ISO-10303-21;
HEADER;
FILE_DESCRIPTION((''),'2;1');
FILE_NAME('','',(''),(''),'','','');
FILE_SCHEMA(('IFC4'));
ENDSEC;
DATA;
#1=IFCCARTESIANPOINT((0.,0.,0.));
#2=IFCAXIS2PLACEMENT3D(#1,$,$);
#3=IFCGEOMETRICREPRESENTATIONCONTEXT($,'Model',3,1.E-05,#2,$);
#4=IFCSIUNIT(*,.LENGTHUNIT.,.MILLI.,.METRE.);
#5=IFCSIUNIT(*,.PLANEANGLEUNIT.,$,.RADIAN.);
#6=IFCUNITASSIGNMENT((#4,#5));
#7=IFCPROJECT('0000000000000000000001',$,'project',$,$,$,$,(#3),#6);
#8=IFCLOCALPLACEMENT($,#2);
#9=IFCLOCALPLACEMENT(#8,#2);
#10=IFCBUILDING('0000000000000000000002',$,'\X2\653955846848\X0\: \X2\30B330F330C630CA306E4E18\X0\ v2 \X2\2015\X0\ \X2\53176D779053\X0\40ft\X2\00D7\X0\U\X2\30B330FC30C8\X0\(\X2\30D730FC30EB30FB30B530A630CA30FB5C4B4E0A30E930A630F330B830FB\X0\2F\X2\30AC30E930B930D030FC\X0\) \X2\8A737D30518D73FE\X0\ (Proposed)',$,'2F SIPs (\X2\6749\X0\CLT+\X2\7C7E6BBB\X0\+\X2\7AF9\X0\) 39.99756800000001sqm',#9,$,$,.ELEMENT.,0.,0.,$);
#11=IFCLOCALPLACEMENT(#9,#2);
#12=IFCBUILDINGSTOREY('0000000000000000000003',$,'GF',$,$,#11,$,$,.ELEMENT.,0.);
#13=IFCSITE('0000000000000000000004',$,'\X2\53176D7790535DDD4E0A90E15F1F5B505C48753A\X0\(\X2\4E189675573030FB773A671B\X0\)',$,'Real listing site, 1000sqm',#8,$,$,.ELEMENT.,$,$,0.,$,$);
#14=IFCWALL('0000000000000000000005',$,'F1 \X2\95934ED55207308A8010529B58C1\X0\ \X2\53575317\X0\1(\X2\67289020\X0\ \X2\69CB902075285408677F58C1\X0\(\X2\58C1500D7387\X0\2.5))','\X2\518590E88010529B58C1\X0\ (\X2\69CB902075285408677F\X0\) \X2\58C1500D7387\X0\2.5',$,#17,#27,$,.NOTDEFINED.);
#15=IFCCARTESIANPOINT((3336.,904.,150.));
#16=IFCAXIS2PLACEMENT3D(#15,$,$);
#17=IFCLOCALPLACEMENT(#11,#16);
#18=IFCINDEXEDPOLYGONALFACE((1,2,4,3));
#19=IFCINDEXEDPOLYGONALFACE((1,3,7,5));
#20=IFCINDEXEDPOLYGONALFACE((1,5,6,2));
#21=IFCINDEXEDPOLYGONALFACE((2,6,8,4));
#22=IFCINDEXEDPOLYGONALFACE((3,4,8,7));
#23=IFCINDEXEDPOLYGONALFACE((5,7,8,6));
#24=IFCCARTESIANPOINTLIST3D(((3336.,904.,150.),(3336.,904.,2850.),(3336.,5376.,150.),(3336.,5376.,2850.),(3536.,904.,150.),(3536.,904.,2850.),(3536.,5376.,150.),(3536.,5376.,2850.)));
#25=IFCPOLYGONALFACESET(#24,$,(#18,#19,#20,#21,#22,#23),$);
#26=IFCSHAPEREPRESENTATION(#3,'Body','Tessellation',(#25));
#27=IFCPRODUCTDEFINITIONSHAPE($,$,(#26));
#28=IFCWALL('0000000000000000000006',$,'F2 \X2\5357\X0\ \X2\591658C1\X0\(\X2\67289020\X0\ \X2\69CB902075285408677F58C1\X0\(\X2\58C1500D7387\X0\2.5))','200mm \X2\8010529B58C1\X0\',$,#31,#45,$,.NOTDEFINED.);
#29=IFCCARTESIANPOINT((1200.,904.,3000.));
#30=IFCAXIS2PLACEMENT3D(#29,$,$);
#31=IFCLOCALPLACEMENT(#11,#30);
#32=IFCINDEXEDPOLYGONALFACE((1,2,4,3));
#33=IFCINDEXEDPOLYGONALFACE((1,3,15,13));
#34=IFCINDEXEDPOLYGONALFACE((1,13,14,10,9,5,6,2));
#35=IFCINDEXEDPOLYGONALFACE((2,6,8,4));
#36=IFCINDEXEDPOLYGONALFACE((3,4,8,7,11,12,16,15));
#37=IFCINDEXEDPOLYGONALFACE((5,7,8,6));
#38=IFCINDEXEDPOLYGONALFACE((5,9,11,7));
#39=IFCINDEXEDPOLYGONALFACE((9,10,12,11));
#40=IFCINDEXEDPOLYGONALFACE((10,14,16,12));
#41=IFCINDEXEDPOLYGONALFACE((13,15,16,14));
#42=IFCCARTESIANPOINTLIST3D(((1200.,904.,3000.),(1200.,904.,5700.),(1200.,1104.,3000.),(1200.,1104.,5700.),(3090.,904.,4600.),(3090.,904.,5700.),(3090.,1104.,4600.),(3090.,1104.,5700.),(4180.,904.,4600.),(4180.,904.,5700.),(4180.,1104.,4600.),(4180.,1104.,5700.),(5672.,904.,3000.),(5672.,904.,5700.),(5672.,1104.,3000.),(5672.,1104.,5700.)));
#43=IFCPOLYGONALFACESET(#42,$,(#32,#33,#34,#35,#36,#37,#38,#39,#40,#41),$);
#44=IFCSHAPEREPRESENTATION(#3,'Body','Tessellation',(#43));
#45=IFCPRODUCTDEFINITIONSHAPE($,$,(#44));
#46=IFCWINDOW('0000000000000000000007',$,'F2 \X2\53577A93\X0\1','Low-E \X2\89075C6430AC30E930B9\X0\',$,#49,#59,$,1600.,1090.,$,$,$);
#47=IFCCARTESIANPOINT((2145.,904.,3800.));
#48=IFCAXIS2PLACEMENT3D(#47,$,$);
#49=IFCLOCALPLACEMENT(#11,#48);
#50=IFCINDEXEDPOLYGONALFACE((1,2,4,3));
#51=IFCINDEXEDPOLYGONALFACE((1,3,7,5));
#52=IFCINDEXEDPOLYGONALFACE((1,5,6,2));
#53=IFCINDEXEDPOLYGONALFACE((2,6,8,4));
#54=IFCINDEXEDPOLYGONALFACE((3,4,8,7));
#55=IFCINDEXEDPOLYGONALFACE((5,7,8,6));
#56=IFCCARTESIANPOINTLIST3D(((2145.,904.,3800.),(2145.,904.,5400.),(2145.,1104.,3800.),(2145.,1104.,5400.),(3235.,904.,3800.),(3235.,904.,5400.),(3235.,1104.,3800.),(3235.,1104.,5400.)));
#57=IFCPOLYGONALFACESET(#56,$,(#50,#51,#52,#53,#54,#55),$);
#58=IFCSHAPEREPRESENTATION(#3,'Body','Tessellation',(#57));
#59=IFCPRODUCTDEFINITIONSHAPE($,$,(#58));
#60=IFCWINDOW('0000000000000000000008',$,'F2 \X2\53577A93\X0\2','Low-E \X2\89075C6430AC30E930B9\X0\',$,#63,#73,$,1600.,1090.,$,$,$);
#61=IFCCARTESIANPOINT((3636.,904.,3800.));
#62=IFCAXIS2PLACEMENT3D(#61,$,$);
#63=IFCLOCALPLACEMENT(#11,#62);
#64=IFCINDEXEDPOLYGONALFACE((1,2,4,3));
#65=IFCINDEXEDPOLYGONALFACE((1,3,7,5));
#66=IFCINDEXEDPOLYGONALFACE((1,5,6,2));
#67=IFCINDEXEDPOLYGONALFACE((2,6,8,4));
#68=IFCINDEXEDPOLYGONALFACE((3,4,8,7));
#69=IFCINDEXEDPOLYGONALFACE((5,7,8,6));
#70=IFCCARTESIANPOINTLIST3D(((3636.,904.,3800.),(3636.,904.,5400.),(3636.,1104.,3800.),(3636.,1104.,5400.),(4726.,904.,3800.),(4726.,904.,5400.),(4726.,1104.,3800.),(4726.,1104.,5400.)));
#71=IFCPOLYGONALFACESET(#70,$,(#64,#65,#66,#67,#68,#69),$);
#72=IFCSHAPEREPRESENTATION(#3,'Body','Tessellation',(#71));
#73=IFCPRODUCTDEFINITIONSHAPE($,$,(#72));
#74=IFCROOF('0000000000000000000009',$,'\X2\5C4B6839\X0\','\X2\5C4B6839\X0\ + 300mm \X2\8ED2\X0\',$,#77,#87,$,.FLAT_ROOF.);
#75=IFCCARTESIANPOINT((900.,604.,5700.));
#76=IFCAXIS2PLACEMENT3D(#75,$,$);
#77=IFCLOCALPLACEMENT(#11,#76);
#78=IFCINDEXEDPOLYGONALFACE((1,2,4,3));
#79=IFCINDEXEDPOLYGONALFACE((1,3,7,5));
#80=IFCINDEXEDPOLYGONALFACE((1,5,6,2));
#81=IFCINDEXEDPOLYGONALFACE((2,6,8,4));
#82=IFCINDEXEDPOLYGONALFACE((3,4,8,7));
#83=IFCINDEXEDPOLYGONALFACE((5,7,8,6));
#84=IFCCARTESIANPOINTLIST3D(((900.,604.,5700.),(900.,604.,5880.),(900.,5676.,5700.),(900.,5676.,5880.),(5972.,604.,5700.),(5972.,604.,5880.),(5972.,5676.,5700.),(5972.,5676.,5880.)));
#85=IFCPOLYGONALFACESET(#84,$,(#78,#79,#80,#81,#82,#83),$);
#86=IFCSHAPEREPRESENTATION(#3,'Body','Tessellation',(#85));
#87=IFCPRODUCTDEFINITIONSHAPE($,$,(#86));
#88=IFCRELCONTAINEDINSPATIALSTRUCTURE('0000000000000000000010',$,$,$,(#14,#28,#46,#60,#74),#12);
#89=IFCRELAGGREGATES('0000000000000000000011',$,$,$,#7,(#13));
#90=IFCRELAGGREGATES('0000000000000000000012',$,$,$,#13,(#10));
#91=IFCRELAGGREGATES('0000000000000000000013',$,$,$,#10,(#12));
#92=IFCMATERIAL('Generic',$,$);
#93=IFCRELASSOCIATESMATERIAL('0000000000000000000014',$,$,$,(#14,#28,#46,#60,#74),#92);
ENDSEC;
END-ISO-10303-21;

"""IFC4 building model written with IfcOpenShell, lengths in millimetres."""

from ifc_helpers import new_model, si_unit, frame, frame_2d, origin, place, context, project, spatial, rectangle, extrude, material, element, fill, save


model = new_model("IFC4")

# Units and contexts
model_context = context("Model", 3, precision=1e-05, world=origin())
ifc_project = project(units=[si_unit("LENGTHUNIT", "METRE", prefix="MILLI"), si_unit("PLANEANGLEUNIT", "RADIAN")], contexts=[model_context])

# Site, building, storey
site_placement = place(None, origin())
site = spatial("IfcSite", under=ifc_project, at=site_placement, Name="北海道川上郡弟子屈町(丘陵地・眺望)", ObjectType="Real listing site, 1000sqm", CompositionType="ELEMENT", RefElevation=0.0)
building_placement = place(site_placement, origin())
building = spatial("IfcBuilding", under=site, at=building_placement, Name="改善案: コンテナの丘 v2 ― 北海道40ft×Uコート(プール・サウナ・屋上ラウンジ・2Fガラスバー) 詳細再現 (Proposed)", ObjectType="2F SIPs (杉CLT+籾殻+竹) 39.99756800000001sqm", CompositionType="ELEMENT", ElevationOfRefHeight=0.0, ElevationOfTerrain=0.0)
storey_placement = place(building_placement, origin())
storey = spatial("IfcBuildingStorey", under=building, at=storey_placement, Name="GF", CompositionType="ELEMENT", Elevation=0.0)

# Shared definitions
ifc_material_1 = material(Name="Generic")

# Wall
wall_1_placement = place(storey_placement, frame((3336.0, 904.0, 150.0)))
element("IfcWall", 1, at=wall_1_placement, inside=storey, material=ifc_material_1, Name="F1 間仕切り耐力壁 南北1(木造 構造用合板壁(壁倍率2.5))", Description="内部耐力壁 (構造用合板) 壁倍率2.5", PredefinedType="NOTDEFINED", context=model_context, shape_type="SweptSolid", body=[
    extrude(rectangle(XDim=200.0, YDim=4472.0, at=frame_2d((100.0, 2236.0))), frame((3336.0, 904.0, 150.0)), (0.0, 0.0, 1.0), 2700.0),
])

# Wall, openings, windows
wall_2_placement = place(storey_placement, frame((1200.0, 904.0, 3000.0)))
wall_2 = element("IfcWall", 2, at=wall_2_placement, inside=storey, material=ifc_material_1, Name="F2 南 外壁(木造 構造用合板壁(壁倍率2.5))", Description="200mm 耐力壁", PredefinedType="NOTDEFINED", context=model_context, shape_type="SweptSolid", body=[
    extrude(rectangle(XDim=4472.0, YDim=200.0, at=frame_2d((2236.0, 100.0))), frame((1200.0, 904.0, 3000.0)), (0.0, 0.0, 1.0), 2700.0),
])
opening_1_placement = place(storey_placement, frame((2145.0, 904.0, 3800.0)))
opening_1 = element("IfcOpeningElement", 3, at=opening_1_placement, cuts=wall_2, PredefinedType="NOTDEFINED", context=model_context, shape_type="SweptSolid", body=[
    extrude(rectangle(XDim=1090.0, YDim=200.0, at=frame_2d((545.0, 100.0))), frame((2145.0, 904.0, 3800.0)), (0.0, 0.0, 1.0), 1600.0),
])
opening_2_placement = place(storey_placement, frame((3636.0, 904.0, 3800.0)))
opening_2 = element("IfcOpeningElement", 4, at=opening_2_placement, cuts=wall_2, PredefinedType="NOTDEFINED", context=model_context, shape_type="SweptSolid", body=[
    extrude(rectangle(XDim=1090.0, YDim=200.0, at=frame_2d((545.0, 100.0))), frame((3636.0, 904.0, 3800.0)), (0.0, 0.0, 1.0), 1600.0),
])
window_1_placement = place(storey_placement, frame((2145.0, 904.0, 3800.0)))
window_1 = element("IfcWindow", 5, at=window_1_placement, inside=storey, material=ifc_material_1, Name="F2 南窓1", Description="Low-E 複層ガラス", OverallHeight=1600.0, OverallWidth=1090.0, context=model_context, shape_type="SweptSolid", body=[
    extrude(rectangle(XDim=1090.0, YDim=200.0, at=frame_2d((545.0, 100.0))), frame((2145.0, 904.0, 3800.0)), (0.0, 0.0, 1.0), 1600.0),
])
fill(opening_1, window_1)
window_2_placement = place(storey_placement, frame((3636.0, 904.0, 3800.0)))
window_2 = element("IfcWindow", 6, at=window_2_placement, inside=storey, material=ifc_material_1, Name="F2 南窓2", Description="Low-E 複層ガラス", OverallHeight=1600.0, OverallWidth=1090.0, context=model_context, shape_type="SweptSolid", body=[
    extrude(rectangle(XDim=1090.0, YDim=200.0, at=frame_2d((545.0, 100.0))), frame((3636.0, 904.0, 3800.0)), (0.0, 0.0, 1.0), 1600.0),
])
fill(opening_2, window_2)

# Roof
roof_placement = place(storey_placement, frame((900.0, 604.0, 5700.0)))
element("IfcRoof", 7, at=roof_placement, inside=storey, material=ifc_material_1, Name="屋根", Description="屋根 + 300mm 軒", PredefinedType="FLAT_ROOF", context=model_context, shape_type="SweptSolid", body=[
    extrude(rectangle(XDim=5072.0, YDim=5072.0, at=frame_2d((2536.0, 2536.0))), frame((900.0, 604.0, 5700.0)), (0.0, 0.0, 1.0), 180.0),
])

save(model, "model.ifc")
